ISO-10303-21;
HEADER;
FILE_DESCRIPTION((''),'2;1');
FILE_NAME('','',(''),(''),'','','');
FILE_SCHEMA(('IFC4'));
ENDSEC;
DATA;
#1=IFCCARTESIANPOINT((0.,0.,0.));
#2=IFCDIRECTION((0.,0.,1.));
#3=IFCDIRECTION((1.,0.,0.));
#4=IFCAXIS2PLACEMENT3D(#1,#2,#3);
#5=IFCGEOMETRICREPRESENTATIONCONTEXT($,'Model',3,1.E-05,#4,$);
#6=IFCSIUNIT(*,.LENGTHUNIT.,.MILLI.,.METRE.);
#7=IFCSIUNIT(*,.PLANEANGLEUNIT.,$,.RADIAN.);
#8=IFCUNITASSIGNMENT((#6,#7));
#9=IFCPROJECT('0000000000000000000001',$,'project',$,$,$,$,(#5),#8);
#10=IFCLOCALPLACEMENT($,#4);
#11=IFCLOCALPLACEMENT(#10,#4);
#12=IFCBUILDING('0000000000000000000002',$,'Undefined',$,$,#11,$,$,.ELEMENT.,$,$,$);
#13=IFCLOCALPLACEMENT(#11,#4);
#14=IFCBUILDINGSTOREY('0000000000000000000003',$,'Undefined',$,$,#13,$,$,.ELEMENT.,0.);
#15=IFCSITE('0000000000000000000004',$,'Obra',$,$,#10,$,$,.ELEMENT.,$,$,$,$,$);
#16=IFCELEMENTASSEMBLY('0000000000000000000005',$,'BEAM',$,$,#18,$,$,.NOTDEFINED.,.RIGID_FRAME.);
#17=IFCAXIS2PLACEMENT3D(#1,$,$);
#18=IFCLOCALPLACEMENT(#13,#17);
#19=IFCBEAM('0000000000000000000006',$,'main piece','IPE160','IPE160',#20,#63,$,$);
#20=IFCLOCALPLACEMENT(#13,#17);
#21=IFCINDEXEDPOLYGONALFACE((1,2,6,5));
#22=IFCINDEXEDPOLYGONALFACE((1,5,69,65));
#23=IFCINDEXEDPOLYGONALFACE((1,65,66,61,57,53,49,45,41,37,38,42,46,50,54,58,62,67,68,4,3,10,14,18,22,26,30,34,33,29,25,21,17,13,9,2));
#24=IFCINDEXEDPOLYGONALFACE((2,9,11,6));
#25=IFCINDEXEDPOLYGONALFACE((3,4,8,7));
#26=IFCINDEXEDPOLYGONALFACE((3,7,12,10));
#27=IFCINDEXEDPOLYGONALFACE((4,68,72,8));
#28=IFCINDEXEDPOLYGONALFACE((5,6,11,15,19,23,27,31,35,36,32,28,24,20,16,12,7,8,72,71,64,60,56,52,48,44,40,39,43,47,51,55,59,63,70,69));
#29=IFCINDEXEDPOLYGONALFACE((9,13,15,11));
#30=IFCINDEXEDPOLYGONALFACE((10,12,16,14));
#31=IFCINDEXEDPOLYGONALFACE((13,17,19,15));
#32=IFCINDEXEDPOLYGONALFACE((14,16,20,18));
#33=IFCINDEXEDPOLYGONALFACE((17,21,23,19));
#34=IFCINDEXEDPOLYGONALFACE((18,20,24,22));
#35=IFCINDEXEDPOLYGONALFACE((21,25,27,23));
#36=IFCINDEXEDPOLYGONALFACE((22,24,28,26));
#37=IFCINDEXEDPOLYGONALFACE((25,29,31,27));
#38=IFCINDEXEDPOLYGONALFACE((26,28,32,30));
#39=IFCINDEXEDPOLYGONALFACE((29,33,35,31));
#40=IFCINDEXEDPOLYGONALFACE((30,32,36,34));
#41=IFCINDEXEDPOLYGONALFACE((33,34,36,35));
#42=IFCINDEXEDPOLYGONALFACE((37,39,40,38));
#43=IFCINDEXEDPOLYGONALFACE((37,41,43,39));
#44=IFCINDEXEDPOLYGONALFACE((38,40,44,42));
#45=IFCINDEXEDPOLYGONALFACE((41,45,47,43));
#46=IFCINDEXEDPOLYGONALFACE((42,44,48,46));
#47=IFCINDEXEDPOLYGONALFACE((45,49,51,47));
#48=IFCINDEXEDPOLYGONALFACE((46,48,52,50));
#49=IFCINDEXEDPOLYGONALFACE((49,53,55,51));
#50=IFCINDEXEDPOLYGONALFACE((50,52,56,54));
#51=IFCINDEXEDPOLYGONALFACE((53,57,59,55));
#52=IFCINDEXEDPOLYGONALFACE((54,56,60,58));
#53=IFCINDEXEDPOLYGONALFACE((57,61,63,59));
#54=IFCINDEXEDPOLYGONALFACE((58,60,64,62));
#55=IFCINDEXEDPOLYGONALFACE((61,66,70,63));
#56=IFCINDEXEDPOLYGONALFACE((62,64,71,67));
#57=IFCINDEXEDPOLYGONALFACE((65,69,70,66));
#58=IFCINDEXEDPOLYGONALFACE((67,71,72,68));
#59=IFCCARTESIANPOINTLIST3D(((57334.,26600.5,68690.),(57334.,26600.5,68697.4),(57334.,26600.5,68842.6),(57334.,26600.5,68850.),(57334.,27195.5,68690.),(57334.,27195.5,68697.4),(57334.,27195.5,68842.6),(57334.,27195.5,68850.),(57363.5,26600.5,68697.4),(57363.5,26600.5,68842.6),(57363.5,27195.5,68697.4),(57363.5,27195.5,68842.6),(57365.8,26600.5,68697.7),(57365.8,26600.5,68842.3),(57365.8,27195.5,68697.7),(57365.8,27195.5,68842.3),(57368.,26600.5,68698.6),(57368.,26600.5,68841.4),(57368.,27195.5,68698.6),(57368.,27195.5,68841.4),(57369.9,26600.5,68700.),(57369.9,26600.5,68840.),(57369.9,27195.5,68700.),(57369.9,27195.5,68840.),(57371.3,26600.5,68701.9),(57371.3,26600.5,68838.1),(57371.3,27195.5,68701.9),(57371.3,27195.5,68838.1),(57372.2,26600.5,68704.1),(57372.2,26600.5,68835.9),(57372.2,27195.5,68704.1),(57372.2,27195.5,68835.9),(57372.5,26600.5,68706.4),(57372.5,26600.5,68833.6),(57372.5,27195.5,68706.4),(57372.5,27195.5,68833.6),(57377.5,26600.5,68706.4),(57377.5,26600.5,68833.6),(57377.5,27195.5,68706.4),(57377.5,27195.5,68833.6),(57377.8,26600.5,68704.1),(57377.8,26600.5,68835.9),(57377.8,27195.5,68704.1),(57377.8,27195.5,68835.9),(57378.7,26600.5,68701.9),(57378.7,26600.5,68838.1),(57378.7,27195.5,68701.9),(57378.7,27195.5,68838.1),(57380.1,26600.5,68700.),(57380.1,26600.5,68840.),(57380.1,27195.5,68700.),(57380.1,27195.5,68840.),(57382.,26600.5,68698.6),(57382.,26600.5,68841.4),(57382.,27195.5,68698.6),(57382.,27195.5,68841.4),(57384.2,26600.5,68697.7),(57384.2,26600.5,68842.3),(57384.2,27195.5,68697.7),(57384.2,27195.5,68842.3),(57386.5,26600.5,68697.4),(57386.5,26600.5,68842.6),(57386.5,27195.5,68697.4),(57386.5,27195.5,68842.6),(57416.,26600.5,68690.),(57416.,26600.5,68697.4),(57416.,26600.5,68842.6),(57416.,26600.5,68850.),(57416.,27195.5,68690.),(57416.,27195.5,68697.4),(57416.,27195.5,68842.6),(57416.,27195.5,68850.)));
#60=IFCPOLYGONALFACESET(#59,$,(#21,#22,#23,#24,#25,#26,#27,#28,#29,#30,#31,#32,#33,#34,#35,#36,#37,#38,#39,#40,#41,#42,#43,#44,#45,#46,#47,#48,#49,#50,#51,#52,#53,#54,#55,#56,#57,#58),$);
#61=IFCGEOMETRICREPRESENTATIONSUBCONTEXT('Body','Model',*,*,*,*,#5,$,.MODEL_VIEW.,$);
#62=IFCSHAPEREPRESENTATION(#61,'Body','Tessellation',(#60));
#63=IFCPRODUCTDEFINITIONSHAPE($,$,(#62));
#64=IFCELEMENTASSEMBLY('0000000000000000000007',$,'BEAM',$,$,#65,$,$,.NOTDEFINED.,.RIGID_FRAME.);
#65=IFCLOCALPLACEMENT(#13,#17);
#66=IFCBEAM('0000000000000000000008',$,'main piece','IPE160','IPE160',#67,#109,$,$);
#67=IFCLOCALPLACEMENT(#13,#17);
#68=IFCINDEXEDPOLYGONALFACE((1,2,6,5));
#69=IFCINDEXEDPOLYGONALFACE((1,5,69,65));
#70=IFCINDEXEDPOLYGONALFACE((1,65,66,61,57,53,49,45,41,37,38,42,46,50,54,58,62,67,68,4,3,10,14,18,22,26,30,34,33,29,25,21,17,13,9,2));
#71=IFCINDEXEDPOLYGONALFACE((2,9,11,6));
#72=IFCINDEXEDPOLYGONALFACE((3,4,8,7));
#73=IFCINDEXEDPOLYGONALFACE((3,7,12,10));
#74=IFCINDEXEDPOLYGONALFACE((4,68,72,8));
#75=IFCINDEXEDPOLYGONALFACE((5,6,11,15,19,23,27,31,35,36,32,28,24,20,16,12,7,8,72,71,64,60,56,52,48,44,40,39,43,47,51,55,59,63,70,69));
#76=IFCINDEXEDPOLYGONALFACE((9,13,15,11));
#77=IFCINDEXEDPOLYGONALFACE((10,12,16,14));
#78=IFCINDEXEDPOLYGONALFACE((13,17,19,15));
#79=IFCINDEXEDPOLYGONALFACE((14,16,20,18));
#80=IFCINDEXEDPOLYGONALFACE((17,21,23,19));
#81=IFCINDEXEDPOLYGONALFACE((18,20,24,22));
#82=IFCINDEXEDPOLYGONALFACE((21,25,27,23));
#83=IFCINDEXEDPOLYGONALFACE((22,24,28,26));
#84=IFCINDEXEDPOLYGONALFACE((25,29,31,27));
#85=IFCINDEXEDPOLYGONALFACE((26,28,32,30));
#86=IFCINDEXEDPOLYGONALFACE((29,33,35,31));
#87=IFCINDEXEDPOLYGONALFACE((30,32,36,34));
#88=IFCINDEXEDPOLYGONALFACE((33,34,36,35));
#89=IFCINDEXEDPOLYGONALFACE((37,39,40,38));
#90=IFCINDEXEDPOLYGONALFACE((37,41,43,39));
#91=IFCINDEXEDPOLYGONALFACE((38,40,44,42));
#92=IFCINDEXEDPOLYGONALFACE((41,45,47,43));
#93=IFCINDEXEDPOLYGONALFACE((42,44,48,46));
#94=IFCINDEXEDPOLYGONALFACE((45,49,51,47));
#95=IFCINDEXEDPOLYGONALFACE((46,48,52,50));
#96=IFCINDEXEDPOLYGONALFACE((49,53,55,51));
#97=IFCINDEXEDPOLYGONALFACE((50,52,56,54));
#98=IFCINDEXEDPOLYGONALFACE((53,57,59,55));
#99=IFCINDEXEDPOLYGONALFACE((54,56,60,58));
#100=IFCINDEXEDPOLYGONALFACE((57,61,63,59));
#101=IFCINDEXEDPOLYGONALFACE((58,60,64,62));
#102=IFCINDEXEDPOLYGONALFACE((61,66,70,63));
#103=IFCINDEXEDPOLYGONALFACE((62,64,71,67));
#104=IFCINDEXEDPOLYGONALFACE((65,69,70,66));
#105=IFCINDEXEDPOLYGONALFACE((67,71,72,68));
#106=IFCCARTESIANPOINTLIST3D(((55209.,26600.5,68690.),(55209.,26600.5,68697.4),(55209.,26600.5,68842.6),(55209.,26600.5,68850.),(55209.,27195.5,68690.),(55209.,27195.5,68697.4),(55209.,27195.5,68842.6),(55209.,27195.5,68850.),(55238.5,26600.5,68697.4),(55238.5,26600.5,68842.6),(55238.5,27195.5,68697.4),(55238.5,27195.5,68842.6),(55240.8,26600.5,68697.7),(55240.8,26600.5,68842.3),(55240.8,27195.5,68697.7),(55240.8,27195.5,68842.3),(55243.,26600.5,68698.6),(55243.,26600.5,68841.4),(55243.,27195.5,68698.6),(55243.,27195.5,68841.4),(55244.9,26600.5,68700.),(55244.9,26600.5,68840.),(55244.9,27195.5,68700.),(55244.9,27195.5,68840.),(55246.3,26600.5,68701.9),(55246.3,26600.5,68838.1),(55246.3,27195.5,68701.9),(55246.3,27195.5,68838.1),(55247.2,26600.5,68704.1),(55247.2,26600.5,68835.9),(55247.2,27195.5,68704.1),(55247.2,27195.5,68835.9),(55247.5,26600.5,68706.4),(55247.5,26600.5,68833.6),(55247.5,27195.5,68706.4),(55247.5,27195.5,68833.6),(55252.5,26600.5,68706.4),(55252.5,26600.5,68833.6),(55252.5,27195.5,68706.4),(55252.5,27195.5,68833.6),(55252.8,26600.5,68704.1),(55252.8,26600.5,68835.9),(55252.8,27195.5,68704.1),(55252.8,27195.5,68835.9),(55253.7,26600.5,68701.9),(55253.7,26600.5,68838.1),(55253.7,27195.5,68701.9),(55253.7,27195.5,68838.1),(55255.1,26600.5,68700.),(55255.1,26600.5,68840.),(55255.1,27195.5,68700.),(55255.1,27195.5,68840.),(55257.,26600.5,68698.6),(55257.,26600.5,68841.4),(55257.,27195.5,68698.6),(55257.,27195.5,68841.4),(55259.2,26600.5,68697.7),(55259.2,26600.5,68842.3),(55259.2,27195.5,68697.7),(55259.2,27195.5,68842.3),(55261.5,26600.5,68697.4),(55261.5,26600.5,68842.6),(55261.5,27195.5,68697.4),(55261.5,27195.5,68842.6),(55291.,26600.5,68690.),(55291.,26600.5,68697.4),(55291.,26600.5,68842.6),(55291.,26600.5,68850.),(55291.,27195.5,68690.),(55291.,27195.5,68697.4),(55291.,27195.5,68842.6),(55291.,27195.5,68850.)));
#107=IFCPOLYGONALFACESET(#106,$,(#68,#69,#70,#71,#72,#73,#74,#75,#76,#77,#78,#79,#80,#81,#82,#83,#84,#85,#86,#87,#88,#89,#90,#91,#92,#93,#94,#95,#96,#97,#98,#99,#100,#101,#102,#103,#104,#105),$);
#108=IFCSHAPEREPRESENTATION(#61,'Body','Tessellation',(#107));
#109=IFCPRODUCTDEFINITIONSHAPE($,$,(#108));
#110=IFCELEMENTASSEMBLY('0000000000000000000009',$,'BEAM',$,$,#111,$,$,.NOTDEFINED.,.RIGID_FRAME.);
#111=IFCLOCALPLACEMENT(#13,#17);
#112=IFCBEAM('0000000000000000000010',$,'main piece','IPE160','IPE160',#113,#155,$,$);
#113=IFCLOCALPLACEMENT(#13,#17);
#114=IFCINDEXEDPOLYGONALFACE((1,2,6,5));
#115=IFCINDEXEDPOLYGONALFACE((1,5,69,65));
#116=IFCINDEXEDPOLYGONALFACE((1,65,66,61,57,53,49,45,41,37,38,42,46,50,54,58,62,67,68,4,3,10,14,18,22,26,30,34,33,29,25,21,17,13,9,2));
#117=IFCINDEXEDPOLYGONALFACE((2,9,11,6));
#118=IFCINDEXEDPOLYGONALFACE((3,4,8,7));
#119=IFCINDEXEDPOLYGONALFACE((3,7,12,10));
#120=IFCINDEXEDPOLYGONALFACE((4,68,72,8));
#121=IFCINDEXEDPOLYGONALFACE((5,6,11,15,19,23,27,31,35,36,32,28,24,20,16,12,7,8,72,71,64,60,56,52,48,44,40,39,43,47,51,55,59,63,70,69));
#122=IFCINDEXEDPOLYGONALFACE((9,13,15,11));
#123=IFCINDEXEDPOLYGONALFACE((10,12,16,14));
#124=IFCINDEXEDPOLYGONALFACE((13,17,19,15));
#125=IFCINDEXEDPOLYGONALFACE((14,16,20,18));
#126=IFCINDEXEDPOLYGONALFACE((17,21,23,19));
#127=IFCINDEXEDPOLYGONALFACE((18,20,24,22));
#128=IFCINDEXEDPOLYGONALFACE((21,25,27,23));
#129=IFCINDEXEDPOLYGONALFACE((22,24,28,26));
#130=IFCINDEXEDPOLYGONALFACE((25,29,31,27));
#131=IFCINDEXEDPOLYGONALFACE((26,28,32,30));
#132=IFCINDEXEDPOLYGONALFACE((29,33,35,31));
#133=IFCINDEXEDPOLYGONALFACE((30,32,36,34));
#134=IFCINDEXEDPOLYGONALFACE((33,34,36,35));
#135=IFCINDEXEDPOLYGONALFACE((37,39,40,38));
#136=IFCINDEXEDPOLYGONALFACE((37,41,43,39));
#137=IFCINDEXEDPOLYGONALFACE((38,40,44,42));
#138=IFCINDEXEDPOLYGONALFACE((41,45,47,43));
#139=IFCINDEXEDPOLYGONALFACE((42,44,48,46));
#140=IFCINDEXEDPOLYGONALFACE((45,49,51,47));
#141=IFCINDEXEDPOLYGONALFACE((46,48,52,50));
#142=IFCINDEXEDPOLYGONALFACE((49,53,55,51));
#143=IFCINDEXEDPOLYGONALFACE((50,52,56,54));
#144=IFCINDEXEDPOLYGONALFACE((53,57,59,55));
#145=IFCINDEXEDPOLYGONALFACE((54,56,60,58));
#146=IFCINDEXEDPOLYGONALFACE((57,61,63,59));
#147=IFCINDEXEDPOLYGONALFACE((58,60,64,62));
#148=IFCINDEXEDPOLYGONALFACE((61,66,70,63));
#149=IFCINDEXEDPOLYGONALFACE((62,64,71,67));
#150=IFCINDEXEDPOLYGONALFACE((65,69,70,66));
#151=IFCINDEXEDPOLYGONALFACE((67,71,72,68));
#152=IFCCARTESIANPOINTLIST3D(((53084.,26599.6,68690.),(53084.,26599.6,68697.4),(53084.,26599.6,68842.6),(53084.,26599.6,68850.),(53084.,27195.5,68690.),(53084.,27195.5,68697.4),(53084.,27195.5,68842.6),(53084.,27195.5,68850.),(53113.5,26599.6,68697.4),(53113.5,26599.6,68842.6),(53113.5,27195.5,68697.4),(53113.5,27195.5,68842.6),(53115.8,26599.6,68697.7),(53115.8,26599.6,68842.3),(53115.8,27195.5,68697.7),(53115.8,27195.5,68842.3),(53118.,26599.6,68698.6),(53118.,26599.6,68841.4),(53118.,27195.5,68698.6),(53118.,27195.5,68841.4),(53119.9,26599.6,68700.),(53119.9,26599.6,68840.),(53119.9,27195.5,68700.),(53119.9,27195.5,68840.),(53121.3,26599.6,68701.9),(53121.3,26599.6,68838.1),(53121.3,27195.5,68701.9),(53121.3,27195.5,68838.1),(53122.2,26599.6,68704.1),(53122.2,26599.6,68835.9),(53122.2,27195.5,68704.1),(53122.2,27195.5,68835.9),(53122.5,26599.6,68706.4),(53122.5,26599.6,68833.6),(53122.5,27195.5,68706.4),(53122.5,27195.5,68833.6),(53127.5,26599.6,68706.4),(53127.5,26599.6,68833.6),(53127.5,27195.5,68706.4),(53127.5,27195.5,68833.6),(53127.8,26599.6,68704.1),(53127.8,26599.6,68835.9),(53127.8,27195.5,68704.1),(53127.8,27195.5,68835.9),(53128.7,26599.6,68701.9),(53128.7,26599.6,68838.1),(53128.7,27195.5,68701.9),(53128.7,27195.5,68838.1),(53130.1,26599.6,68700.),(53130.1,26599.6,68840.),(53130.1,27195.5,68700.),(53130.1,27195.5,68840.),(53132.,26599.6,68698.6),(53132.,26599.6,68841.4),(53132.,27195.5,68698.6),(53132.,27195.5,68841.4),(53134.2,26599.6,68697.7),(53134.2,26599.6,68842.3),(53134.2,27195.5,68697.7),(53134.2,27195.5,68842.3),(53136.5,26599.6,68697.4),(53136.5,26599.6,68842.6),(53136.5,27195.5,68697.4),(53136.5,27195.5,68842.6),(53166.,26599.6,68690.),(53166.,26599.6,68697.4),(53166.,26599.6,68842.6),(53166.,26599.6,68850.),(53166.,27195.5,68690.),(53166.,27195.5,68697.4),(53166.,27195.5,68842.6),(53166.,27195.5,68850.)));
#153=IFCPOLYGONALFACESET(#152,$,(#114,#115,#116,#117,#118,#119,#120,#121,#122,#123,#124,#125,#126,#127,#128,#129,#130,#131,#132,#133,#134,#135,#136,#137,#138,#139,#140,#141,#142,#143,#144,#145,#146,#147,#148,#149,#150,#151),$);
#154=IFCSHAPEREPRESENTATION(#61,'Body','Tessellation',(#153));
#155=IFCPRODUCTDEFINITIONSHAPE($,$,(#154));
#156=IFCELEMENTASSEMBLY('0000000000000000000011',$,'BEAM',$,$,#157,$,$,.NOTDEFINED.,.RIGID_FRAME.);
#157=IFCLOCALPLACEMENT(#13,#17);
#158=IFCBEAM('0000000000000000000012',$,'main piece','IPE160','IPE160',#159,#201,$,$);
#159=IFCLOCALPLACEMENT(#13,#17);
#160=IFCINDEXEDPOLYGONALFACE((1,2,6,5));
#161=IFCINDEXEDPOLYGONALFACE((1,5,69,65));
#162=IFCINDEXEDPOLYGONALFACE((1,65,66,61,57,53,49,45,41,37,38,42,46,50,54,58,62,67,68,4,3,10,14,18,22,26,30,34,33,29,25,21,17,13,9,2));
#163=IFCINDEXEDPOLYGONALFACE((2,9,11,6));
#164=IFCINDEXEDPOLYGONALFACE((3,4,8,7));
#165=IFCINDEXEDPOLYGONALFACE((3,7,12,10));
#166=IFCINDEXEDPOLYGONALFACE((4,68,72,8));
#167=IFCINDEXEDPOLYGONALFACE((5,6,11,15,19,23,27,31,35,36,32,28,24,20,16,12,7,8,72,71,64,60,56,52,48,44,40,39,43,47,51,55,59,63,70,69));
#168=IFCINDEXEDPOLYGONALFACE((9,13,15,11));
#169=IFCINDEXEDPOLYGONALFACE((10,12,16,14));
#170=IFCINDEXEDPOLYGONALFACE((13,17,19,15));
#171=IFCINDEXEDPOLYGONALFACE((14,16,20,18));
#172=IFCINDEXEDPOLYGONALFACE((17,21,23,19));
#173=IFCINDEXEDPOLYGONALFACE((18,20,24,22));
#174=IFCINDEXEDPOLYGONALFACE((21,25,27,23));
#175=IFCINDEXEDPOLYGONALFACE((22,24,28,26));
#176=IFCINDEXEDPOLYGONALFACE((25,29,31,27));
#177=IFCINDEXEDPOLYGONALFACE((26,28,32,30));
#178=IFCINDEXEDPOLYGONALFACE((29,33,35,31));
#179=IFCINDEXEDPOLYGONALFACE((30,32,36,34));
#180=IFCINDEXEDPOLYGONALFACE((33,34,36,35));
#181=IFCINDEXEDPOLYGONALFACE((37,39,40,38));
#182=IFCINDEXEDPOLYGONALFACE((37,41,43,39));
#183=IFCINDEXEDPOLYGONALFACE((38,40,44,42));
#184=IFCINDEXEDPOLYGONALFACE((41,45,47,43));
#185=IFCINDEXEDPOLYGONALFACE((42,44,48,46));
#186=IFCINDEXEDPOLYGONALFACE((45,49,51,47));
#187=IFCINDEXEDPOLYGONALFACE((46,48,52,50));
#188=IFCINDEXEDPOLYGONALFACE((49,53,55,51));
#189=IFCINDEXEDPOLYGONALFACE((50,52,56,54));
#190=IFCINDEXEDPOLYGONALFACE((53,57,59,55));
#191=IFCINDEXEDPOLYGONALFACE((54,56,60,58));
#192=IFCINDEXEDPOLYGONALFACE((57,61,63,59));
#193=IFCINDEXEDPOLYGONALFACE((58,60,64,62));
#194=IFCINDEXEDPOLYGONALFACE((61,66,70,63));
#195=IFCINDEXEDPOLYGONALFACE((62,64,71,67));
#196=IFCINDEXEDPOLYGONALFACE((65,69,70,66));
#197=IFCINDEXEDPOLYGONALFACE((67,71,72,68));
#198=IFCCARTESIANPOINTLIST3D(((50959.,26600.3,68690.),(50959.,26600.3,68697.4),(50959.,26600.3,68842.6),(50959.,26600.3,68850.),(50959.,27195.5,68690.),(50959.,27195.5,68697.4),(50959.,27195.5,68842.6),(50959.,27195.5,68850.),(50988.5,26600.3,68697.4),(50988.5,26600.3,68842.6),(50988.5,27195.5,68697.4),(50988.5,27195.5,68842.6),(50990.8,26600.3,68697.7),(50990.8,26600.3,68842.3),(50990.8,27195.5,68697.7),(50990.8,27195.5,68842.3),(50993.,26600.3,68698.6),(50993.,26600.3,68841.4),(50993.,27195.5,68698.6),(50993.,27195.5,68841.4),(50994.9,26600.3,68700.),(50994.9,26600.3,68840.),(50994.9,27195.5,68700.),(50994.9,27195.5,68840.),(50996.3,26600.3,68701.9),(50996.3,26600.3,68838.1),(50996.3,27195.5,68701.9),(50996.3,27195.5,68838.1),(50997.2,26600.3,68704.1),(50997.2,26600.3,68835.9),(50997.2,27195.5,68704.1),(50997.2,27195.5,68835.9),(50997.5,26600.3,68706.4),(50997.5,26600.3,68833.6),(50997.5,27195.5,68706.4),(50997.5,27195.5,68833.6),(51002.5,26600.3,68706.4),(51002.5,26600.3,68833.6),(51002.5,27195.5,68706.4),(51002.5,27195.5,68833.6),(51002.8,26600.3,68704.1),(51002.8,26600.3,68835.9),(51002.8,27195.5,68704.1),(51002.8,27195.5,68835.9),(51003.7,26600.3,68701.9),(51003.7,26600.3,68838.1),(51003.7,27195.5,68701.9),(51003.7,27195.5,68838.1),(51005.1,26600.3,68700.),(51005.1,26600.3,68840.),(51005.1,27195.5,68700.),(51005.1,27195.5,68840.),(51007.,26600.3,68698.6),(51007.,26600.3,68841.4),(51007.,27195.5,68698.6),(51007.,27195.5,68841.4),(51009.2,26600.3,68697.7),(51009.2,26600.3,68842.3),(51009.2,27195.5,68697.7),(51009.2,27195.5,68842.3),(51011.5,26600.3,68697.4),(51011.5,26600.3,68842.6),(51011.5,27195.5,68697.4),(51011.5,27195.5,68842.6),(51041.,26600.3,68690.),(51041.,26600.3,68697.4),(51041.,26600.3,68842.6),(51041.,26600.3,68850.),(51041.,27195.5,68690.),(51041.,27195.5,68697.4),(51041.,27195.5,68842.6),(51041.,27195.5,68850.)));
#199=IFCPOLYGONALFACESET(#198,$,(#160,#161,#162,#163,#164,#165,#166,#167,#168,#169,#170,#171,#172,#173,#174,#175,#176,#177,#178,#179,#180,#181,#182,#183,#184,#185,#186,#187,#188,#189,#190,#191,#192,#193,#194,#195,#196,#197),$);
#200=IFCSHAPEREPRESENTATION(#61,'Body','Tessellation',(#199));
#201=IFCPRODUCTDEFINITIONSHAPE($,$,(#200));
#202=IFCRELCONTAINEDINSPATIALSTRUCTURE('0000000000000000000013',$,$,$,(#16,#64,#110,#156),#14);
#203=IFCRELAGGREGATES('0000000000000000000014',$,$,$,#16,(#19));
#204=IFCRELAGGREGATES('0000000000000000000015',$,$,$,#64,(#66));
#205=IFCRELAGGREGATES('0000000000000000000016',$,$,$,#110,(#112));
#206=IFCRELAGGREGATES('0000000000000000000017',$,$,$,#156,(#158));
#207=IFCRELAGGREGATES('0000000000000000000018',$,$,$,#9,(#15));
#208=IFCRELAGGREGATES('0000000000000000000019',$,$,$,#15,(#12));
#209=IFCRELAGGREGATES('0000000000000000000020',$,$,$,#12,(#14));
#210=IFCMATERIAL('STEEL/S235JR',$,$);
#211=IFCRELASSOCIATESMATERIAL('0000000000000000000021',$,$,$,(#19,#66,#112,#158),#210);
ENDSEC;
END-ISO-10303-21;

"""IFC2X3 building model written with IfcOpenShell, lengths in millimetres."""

from ifc_helpers import new_model, si_unit, frame, origin_with_axes, origin_2d_with_axis, place, context, subcontext, project, spatial, i_section, extrude, material, element, aggregate, save


model = new_model("IFC2X3")

# Units and contexts
model_context = context("Model", 3, precision=1e-05, world=origin_with_axes())
body_context = subcontext(model_context, "Body", "Model", "MODEL_VIEW")
ifc_project = project(units=[si_unit("LENGTHUNIT", "METRE", prefix="MILLI"), si_unit("PLANEANGLEUNIT", "RADIAN")], contexts=[model_context])

# Site, building, storey
site_placement = place(None, origin_with_axes())
site = spatial("IfcSite", under=ifc_project, at=site_placement, Name="Obra", CompositionType="ELEMENT")
building_placement = place(site_placement, origin_with_axes())
building = spatial("IfcBuilding", under=site, at=building_placement, Name="Undefined", CompositionType="ELEMENT")
storey_placement = place(building_placement, origin_with_axes())
storey = spatial("IfcBuildingStorey", under=building, at=storey_placement, Name="Undefined", CompositionType="ELEMENT", Elevation=0.0)

# Element assemblies, beams
ifc_material_1 = material(Name="STEEL/S235JR")
assembly_1_placement = place(storey_placement, origin_with_axes())
assembly_1 = element("IfcElementAssembly", 1, at=assembly_1_placement, inside=storey, Name="BEAM", AssemblyPlace="NOTDEFINED", PredefinedType="RIGID_FRAME")
beam_1_placement = place(assembly_1_placement, frame((57375.0, 27195.5, 68770.0), z_axis=(0.0, 0.0, 1.0), x_axis=(0.0, -1.0, 0.0)))
beam_1 = element("IfcBeam", 2, at=beam_1_placement, material=ifc_material_1, Name="main piece", Description="IPE160", ObjectType="IPE160", context=body_context, shape_type="SweptSolid", body=[
    extrude(i_section(OverallWidth=82.0, OverallDepth=160.0, WebThickness=5.0, FlangeThickness=7.4, FilletRadius=9.0, at=origin_2d_with_axis()), frame((595.0, 0.0, 0.0), z_axis=(-1.0, 0.0, 0.0), x_axis=(0.0, -1.0, 0.0)), (0.0, 0.0, 1.0), 595.0),
])
aggregate(assembly_1, [beam_1])
assembly_2_placement = place(storey_placement, origin_with_axes())
assembly_2 = element("IfcElementAssembly", 3, at=assembly_2_placement, inside=storey, Name="BEAM", AssemblyPlace="NOTDEFINED", PredefinedType="RIGID_FRAME")
beam_2_placement = place(assembly_2_placement, frame((55250.0, 26600.5, 68770.0), z_axis=(0.0, 0.0, 1.0), x_axis=(0.0, 1.0, 0.0)))
beam_2 = element("IfcBeam", 4, at=beam_2_placement, material=ifc_material_1, Name="main piece", Description="IPE160", ObjectType="IPE160", context=body_context, shape_type="SweptSolid", body=[
    extrude(i_section(OverallWidth=82.0, OverallDepth=160.0, WebThickness=5.0, FlangeThickness=7.4, FilletRadius=9.0, at=origin_2d_with_axis()), frame((595.0, 0.0, 0.0), z_axis=(-1.0, 0.0, 0.0), x_axis=(0.0, -1.0, 0.0)), (0.0, 0.0, 1.0), 595.0),
])
aggregate(assembly_2, [beam_2])
assembly_3_placement = place(storey_placement, origin_with_axes())
assembly_3 = element("IfcElementAssembly", 5, at=assembly_3_placement, inside=storey, Name="BEAM", AssemblyPlace="NOTDEFINED", PredefinedType="RIGID_FRAME")
beam_3_placement = place(assembly_3_placement, frame((53125.0, 26599.6, 68770.0), z_axis=(0.0, 0.0, 1.0), x_axis=(0.0, 1.0, 0.0)))
beam_3 = element("IfcBeam", 6, at=beam_3_placement, material=ifc_material_1, Name="main piece", Description="IPE160", ObjectType="IPE160", context=body_context, shape_type="SweptSolid", body=[
    extrude(i_section(OverallWidth=82.0, OverallDepth=160.0, WebThickness=5.0, FlangeThickness=7.4, FilletRadius=9.0, at=origin_2d_with_axis()), frame((595.9, 0.0, 0.0), z_axis=(-1.0, 0.0, 0.0), x_axis=(0.0, -1.0, 0.0)), (0.0, 0.0, 1.0), 595.9),
])
aggregate(assembly_3, [beam_3])
assembly_4_placement = place(storey_placement, origin_with_axes())
assembly_4 = element("IfcElementAssembly", 7, at=assembly_4_placement, inside=storey, Name="BEAM", AssemblyPlace="NOTDEFINED", PredefinedType="RIGID_FRAME")
beam_4_placement = place(assembly_4_placement, frame((51000.0, 26600.3, 68770.0), z_axis=(0.0, 0.0, 1.0), x_axis=(0.0, 1.0, 0.0)))
beam_4 = element("IfcBeam", 8, at=beam_4_placement, material=ifc_material_1, Name="main piece", Description="IPE160", ObjectType="IPE160", context=body_context, shape_type="SweptSolid", body=[
    extrude(i_section(OverallWidth=82.0, OverallDepth=160.0, WebThickness=5.0, FlangeThickness=7.4, FilletRadius=9.0, at=origin_2d_with_axis()), frame((595.2, 0.0, 0.0), z_axis=(-1.0, 0.0, 0.0), x_axis=(0.0, -1.0, 0.0)), (0.0, 0.0, 1.0), 595.2),
])
aggregate(assembly_4, [beam_4])

save(model, "model.ifc")
